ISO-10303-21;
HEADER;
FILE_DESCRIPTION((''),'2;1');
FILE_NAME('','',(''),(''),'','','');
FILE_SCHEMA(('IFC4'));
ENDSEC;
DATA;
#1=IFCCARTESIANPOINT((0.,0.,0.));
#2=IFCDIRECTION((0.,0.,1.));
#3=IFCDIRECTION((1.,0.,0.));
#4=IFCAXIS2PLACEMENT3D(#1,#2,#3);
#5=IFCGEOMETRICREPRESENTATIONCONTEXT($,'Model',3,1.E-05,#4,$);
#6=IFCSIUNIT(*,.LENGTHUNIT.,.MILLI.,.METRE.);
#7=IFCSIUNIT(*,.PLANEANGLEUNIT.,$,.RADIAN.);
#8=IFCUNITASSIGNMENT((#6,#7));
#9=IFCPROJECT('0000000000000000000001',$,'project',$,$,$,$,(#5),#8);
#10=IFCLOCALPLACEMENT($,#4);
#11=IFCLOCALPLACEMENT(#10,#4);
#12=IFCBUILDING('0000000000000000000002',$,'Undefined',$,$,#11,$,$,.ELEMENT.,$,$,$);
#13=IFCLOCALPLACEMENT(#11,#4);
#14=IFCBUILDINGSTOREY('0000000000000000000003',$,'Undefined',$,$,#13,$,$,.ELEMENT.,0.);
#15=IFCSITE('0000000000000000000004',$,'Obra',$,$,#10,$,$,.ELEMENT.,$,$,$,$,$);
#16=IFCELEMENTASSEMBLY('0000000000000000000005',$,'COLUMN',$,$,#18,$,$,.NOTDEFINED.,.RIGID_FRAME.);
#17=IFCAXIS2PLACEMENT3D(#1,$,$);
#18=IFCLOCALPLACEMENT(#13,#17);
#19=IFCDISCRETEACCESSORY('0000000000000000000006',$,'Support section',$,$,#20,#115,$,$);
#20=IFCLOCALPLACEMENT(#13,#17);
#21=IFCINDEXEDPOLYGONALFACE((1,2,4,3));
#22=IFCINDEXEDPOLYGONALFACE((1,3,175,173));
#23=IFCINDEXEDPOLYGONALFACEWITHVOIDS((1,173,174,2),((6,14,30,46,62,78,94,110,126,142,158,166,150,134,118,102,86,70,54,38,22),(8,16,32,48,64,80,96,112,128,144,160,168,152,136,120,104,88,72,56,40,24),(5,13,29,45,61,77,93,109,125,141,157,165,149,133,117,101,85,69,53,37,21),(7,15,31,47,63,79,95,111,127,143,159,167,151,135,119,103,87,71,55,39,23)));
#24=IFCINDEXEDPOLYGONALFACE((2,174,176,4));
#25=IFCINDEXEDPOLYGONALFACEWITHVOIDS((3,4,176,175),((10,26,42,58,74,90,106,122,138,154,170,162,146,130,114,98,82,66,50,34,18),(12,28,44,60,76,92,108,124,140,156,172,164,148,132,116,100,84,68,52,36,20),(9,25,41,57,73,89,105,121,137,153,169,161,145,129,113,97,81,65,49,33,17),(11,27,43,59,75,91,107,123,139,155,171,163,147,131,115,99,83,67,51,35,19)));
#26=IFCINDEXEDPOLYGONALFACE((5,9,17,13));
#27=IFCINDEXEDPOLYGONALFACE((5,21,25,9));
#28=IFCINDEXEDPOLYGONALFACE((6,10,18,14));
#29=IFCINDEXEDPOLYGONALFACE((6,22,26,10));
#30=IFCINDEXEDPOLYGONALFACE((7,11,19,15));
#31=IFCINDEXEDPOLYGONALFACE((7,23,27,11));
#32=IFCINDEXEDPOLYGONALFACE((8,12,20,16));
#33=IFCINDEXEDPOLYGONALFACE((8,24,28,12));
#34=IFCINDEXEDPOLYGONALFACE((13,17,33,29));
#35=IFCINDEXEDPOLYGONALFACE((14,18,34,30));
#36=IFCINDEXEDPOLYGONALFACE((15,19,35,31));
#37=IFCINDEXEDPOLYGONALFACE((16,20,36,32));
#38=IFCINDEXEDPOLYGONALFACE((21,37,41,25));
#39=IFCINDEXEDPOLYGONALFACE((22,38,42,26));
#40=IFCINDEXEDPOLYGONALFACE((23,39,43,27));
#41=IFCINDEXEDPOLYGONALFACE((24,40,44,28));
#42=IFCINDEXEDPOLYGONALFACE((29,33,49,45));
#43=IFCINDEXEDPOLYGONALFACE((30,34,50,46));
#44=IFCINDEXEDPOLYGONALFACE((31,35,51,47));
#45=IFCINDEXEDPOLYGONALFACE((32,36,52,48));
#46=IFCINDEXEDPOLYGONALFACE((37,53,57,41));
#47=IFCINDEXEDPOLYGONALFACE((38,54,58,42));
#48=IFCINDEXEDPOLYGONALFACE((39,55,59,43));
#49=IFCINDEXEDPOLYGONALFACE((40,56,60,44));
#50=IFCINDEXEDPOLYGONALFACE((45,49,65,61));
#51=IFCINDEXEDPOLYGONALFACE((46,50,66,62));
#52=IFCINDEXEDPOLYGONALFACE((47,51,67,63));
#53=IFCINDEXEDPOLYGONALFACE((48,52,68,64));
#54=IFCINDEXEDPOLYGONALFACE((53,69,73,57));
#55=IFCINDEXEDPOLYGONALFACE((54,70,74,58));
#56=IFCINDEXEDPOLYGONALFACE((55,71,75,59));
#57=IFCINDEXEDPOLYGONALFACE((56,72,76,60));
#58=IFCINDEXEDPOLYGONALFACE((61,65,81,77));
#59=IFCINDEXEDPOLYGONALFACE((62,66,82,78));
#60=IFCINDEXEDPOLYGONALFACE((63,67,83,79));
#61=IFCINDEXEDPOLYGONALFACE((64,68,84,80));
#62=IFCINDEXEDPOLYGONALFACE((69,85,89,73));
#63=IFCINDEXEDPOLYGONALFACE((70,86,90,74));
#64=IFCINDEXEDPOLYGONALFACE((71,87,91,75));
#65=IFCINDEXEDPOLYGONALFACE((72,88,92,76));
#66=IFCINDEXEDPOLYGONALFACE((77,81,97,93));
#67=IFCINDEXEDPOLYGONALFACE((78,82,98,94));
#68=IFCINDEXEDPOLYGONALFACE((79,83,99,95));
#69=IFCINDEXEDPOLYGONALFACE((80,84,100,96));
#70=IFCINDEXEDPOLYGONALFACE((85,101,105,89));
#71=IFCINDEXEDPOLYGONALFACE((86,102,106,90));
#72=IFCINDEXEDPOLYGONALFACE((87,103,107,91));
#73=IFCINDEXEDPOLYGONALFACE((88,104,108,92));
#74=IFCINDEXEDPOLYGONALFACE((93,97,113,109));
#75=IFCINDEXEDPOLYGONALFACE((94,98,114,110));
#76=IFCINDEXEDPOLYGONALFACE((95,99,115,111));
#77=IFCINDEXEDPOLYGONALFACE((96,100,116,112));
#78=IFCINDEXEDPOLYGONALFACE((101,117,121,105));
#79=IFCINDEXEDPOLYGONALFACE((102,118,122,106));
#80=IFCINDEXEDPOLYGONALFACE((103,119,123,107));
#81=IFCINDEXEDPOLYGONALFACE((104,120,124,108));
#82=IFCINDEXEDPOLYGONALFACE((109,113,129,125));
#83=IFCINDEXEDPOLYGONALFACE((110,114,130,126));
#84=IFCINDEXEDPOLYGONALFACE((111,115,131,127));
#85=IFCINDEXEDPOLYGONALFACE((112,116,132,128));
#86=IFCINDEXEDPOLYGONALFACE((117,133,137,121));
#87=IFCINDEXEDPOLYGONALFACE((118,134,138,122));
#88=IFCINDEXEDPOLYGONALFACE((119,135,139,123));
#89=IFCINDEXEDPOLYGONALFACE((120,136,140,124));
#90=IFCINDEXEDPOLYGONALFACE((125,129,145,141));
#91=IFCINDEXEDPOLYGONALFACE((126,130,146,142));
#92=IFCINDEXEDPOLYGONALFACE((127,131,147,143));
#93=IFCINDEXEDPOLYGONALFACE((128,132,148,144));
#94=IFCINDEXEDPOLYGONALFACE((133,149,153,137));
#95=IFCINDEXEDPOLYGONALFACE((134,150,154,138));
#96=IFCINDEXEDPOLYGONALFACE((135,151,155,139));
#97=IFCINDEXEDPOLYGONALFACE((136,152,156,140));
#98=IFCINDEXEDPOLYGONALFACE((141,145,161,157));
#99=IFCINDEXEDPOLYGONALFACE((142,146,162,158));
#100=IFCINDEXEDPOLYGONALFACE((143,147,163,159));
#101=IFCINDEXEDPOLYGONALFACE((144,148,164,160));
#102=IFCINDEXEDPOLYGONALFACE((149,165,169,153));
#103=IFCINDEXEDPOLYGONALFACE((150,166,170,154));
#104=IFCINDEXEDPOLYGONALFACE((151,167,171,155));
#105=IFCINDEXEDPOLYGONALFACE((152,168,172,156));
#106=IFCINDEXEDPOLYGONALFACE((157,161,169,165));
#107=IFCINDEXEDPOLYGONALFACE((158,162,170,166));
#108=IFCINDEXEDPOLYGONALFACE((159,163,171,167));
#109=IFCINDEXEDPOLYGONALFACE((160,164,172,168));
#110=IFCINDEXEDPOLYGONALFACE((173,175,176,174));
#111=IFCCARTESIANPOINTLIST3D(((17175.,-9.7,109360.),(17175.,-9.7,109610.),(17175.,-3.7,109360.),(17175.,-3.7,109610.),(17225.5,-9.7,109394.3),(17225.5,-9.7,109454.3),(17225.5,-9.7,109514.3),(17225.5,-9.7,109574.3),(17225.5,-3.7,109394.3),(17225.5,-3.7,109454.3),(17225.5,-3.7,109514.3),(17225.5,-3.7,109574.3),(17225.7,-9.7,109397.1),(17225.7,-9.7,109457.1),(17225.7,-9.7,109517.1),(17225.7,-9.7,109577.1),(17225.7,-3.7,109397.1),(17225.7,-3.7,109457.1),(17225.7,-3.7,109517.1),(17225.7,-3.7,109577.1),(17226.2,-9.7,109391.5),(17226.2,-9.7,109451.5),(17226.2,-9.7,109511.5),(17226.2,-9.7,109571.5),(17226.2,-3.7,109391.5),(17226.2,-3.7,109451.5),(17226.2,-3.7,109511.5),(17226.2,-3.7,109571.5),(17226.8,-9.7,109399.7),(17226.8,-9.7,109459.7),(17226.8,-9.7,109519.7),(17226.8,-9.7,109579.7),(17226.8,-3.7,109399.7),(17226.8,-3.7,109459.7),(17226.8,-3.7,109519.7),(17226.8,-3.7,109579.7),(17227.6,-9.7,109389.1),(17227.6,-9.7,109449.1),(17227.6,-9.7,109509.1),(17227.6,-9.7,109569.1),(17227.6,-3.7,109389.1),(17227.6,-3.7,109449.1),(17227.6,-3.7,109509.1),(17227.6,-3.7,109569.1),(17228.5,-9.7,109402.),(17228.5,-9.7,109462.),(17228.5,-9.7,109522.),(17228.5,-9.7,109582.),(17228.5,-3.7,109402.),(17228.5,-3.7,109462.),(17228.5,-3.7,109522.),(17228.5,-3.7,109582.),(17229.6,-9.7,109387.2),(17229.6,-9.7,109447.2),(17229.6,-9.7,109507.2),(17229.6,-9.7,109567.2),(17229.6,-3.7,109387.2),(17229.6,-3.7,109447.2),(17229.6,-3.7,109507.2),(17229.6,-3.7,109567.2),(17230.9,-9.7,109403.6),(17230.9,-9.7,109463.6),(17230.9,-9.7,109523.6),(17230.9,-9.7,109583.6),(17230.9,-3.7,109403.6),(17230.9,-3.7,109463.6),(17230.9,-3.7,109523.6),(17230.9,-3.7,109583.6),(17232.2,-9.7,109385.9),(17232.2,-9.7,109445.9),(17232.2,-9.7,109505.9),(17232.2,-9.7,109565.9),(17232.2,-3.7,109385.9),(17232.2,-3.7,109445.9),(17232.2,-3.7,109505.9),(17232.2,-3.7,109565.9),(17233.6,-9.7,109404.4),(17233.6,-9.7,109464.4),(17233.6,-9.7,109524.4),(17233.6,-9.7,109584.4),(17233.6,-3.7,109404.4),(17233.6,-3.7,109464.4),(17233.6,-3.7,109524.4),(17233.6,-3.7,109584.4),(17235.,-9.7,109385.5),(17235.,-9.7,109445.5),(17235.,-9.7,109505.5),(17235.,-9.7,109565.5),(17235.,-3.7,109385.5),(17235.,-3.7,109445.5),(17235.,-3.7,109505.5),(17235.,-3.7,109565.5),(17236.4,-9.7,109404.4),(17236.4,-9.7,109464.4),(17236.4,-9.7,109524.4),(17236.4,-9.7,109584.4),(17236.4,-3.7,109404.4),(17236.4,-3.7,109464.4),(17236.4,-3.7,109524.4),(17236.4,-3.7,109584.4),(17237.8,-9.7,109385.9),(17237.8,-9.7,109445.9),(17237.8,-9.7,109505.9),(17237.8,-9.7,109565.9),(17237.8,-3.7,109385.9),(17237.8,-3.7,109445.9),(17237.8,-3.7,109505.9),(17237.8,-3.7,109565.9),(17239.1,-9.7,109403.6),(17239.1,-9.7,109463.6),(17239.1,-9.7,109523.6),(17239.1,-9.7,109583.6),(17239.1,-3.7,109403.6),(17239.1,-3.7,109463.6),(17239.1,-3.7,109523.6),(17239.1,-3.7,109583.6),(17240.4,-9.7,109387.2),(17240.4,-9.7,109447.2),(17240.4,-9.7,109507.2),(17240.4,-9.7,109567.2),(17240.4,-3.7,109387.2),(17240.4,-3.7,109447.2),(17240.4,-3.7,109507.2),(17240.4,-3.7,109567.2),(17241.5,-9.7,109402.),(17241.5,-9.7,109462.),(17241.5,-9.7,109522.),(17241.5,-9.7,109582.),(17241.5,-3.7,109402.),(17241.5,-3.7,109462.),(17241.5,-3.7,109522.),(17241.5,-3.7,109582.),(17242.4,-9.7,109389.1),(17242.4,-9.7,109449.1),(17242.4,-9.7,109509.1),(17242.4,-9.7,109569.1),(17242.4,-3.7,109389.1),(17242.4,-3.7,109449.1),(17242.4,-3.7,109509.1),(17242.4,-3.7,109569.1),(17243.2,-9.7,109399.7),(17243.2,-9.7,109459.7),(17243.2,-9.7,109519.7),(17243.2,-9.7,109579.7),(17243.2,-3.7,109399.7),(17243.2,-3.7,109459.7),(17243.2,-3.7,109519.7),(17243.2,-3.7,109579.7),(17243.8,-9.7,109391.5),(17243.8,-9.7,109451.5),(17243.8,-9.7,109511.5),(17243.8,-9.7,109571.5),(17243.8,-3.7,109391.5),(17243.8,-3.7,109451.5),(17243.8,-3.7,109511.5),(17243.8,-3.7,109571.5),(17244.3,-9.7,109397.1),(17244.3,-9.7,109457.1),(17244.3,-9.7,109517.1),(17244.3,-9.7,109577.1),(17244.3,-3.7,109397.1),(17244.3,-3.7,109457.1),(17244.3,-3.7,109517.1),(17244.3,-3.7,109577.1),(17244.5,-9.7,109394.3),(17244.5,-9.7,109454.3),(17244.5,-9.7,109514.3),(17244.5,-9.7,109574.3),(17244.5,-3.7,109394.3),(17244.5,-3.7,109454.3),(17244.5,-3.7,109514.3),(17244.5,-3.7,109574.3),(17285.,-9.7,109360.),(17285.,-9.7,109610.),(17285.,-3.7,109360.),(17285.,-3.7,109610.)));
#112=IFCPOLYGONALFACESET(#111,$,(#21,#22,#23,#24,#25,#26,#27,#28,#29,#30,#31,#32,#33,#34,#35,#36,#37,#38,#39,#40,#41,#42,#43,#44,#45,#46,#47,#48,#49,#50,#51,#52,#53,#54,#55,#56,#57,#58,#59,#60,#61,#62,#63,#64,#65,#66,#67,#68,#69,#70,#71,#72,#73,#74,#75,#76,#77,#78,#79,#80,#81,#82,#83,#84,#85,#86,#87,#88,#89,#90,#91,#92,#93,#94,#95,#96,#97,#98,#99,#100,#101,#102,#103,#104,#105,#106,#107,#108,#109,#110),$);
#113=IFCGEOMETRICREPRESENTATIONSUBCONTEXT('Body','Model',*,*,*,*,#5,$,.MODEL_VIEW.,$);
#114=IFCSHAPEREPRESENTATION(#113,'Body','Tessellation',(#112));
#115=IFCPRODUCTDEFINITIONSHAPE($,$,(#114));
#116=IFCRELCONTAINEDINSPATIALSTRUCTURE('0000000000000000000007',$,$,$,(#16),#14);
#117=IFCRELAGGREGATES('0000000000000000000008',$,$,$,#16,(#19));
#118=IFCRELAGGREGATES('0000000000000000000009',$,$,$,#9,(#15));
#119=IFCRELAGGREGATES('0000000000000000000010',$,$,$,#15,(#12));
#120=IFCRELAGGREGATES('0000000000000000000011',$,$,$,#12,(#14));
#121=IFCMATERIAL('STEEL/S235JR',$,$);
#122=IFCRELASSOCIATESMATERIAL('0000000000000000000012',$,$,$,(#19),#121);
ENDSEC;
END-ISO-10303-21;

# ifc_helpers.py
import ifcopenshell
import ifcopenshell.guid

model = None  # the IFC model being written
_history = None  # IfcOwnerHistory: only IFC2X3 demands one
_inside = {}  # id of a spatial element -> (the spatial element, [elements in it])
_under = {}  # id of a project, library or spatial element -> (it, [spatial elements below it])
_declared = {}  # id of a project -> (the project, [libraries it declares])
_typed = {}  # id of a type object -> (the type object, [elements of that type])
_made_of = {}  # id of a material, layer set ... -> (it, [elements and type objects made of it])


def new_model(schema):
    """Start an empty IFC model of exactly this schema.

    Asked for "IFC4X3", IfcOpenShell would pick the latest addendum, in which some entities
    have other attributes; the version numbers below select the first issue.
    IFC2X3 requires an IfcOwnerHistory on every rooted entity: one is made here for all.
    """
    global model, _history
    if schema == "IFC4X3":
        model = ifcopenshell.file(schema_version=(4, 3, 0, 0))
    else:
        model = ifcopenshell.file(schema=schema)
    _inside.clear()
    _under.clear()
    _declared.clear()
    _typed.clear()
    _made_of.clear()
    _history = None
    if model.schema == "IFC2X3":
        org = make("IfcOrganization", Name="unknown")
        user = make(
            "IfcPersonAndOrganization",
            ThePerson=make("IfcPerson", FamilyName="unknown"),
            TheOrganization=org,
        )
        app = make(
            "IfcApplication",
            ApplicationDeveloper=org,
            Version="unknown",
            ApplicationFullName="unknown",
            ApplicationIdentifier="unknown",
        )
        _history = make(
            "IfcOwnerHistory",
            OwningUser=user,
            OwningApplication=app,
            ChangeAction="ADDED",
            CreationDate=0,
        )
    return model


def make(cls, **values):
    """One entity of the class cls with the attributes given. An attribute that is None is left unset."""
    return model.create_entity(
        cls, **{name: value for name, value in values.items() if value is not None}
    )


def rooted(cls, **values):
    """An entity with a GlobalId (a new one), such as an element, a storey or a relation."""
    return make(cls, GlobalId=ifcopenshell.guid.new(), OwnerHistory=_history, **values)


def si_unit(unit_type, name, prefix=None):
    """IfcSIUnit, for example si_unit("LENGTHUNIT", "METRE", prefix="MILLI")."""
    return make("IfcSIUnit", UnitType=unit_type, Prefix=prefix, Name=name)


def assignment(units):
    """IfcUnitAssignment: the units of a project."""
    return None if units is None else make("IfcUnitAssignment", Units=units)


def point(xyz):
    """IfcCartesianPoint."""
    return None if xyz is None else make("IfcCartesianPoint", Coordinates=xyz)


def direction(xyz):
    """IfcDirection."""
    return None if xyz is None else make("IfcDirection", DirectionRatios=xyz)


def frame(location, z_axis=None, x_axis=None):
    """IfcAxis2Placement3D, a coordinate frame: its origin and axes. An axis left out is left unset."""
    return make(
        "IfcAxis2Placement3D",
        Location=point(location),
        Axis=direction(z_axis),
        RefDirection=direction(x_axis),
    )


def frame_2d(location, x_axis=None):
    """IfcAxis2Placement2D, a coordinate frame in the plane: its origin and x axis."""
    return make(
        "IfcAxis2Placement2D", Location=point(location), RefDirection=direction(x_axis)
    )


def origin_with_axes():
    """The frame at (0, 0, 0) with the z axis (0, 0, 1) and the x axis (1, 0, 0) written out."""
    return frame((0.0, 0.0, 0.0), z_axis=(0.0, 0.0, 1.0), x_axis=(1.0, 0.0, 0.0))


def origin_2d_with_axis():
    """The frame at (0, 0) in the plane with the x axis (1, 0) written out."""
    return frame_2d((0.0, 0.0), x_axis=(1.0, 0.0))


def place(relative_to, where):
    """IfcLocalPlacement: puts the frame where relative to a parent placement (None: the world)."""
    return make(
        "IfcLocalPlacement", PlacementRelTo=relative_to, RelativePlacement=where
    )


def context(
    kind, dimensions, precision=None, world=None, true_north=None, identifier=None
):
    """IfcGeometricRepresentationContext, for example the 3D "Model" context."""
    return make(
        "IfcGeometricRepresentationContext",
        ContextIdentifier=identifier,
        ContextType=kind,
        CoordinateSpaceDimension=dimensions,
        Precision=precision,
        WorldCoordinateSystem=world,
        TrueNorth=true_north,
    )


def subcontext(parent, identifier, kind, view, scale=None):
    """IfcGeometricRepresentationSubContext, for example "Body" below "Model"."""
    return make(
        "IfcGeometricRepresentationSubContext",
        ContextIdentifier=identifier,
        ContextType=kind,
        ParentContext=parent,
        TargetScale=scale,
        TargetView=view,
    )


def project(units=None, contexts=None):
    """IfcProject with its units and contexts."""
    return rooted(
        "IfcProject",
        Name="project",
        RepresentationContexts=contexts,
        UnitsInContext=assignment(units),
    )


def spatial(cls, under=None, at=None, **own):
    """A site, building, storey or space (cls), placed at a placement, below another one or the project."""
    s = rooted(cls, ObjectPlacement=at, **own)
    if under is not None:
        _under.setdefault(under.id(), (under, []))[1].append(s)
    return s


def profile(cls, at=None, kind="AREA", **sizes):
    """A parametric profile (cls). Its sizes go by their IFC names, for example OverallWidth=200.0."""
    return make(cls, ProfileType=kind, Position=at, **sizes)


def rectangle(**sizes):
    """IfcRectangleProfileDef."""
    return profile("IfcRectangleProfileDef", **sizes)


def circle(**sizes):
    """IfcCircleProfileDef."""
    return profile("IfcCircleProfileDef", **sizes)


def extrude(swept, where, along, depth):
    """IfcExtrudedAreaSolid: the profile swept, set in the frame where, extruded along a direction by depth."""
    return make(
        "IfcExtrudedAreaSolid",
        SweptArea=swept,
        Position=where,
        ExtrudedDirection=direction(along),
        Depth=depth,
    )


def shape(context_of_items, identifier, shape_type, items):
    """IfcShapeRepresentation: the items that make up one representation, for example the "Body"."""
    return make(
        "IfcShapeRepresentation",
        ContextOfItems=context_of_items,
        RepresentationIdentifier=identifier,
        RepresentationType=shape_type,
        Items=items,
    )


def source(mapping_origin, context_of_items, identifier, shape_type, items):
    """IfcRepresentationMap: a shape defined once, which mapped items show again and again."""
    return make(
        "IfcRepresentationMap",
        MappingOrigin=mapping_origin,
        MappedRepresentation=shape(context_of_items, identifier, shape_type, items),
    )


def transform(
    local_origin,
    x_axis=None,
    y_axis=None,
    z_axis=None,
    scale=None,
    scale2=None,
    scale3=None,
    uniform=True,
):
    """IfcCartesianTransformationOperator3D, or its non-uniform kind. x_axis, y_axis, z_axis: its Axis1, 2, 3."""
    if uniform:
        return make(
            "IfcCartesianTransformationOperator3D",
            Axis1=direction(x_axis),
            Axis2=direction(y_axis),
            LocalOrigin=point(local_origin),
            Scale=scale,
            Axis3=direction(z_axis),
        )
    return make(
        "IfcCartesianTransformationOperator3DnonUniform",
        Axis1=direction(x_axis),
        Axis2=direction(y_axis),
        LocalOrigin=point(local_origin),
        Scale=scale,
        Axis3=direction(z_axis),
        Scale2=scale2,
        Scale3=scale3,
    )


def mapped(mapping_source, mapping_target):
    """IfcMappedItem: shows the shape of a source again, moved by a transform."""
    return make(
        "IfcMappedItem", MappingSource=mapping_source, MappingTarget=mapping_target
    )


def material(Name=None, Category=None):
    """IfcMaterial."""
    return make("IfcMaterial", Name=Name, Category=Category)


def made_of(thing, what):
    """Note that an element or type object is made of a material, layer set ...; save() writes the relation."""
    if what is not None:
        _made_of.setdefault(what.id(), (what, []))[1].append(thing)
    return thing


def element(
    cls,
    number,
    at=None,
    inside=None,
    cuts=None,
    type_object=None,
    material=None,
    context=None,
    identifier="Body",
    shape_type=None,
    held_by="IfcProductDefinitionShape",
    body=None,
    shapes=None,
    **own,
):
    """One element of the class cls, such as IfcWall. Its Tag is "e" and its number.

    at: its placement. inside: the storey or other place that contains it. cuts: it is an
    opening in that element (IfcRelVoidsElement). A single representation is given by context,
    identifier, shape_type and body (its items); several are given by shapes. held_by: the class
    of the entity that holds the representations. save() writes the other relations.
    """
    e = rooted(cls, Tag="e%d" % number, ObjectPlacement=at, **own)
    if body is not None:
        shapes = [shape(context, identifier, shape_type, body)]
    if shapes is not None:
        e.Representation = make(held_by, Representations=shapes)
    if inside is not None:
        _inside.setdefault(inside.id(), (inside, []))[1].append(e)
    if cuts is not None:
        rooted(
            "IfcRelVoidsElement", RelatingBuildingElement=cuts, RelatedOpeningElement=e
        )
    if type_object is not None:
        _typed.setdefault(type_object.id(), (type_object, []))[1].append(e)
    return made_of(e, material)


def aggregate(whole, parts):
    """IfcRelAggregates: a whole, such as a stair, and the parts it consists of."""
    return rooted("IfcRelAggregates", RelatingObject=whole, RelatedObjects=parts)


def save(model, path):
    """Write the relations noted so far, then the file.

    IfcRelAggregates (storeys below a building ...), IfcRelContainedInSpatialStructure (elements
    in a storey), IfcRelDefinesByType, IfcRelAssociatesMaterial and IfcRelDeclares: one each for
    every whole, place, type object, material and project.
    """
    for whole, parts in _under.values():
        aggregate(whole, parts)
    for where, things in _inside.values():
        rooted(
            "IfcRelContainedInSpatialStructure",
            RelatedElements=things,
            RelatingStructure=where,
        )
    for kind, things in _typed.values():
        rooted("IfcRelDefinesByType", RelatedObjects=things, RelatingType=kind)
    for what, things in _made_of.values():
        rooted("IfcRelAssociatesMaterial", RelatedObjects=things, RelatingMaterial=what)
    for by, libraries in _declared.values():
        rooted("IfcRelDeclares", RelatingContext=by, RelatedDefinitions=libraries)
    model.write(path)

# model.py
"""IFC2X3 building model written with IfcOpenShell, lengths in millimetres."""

from ifc_helpers import new_model, si_unit, frame, origin_with_axes, origin_2d_with_axis, place, context, subcontext, project, spatial, rectangle, circle, extrude, source, transform, mapped, material, element, aggregate, save


model = new_model("IFC2X3")

# Units and contexts
model_context = context("Model", 3, precision=1e-05, world=origin_with_axes())
body_context = subcontext(model_context, "Body", "Model", "MODEL_VIEW")
ifc_project = project(units=[si_unit("LENGTHUNIT", "METRE", prefix="MILLI"), si_unit("PLANEANGLEUNIT", "RADIAN")], contexts=[model_context])

# Site, building, storey
site_placement = place(None, origin_with_axes())
site = spatial("IfcSite", under=ifc_project, at=site_placement, Name="Obra", CompositionType="ELEMENT")
building_placement = place(site_placement, origin_with_axes())
building = spatial("IfcBuilding", under=site, at=building_placement, Name="Undefined", CompositionType="ELEMENT")
storey_placement = place(building_placement, origin_with_axes())
storey = spatial("IfcBuildingStorey", under=building, at=storey_placement, Name="Undefined", CompositionType="ELEMENT", Elevation=0.0)

# Shared definitions
ifc_material_1 = material(Name="STEEL/S235JR")

# Element assembly, discrete accessory, opening
assembly_1_placement = place(storey_placement, origin_with_axes())
assembly_1 = element("IfcElementAssembly", 1, at=assembly_1_placement, inside=storey, Name="COLUMN", AssemblyPlace="NOTDEFINED", PredefinedType="RIGID_FRAME")
shared_shape_1 = source(origin_with_axes(), body_context, "Body", "SweptSolid", [
    extrude(circle(Radius=9.5, at=origin_2d_with_axis()), frame((0.0, -9.9, 0.0), z_axis=(0.0, 1.0, 0.0), x_axis=(1.0, 0.0, 0.0)), (0.0, 0.0, 1.0), 6.2),
])
discrete_accessory_1_placement = place(assembly_1_placement, frame((17230.0, -6.7, 109360.0), z_axis=(0.0, 0.0, 1.0), x_axis=(-1.0, 0.0, 0.0)))
discrete_accessory_1 = element("IfcDiscreteAccessory", 2, at=discrete_accessory_1_placement, material=ifc_material_1, Name="Support section", context=body_context, shape_type="SweptSolid", body=[
    extrude(rectangle(XDim=6.0, YDim=110.0, at=origin_2d_with_axis()), frame((0.0, 0.0, 250.0), z_axis=(0.0, 0.0, -1.0), x_axis=(0.0, 1.0, 0.0)), (0.0, 0.0, 1.0), 250.0),
])
opening_1_placement = place(assembly_1_placement, frame((17185.0, 0.0, 109650.0), z_axis=(1.0, 0.0, 0.0), x_axis=(0.0, 0.0, -1.0)))
element("IfcOpeningElement", 3, at=opening_1_placement, cuts=discrete_accessory_1, ObjectType="Opening", context=body_context, shape_type="MappedRepresentation", body=[
    mapped(shared_shape_1, transform((75.0, 0.0, 50.0))),
    mapped(shared_shape_1, transform((135.0, 0.0, 50.0))),
    mapped(shared_shape_1, transform((195.0, 0.0, 50.0))),
    mapped(shared_shape_1, transform((255.0, 0.0, 50.0))),
])
aggregate(assembly_1, [discrete_accessory_1])

save(model, "model.ifc")
